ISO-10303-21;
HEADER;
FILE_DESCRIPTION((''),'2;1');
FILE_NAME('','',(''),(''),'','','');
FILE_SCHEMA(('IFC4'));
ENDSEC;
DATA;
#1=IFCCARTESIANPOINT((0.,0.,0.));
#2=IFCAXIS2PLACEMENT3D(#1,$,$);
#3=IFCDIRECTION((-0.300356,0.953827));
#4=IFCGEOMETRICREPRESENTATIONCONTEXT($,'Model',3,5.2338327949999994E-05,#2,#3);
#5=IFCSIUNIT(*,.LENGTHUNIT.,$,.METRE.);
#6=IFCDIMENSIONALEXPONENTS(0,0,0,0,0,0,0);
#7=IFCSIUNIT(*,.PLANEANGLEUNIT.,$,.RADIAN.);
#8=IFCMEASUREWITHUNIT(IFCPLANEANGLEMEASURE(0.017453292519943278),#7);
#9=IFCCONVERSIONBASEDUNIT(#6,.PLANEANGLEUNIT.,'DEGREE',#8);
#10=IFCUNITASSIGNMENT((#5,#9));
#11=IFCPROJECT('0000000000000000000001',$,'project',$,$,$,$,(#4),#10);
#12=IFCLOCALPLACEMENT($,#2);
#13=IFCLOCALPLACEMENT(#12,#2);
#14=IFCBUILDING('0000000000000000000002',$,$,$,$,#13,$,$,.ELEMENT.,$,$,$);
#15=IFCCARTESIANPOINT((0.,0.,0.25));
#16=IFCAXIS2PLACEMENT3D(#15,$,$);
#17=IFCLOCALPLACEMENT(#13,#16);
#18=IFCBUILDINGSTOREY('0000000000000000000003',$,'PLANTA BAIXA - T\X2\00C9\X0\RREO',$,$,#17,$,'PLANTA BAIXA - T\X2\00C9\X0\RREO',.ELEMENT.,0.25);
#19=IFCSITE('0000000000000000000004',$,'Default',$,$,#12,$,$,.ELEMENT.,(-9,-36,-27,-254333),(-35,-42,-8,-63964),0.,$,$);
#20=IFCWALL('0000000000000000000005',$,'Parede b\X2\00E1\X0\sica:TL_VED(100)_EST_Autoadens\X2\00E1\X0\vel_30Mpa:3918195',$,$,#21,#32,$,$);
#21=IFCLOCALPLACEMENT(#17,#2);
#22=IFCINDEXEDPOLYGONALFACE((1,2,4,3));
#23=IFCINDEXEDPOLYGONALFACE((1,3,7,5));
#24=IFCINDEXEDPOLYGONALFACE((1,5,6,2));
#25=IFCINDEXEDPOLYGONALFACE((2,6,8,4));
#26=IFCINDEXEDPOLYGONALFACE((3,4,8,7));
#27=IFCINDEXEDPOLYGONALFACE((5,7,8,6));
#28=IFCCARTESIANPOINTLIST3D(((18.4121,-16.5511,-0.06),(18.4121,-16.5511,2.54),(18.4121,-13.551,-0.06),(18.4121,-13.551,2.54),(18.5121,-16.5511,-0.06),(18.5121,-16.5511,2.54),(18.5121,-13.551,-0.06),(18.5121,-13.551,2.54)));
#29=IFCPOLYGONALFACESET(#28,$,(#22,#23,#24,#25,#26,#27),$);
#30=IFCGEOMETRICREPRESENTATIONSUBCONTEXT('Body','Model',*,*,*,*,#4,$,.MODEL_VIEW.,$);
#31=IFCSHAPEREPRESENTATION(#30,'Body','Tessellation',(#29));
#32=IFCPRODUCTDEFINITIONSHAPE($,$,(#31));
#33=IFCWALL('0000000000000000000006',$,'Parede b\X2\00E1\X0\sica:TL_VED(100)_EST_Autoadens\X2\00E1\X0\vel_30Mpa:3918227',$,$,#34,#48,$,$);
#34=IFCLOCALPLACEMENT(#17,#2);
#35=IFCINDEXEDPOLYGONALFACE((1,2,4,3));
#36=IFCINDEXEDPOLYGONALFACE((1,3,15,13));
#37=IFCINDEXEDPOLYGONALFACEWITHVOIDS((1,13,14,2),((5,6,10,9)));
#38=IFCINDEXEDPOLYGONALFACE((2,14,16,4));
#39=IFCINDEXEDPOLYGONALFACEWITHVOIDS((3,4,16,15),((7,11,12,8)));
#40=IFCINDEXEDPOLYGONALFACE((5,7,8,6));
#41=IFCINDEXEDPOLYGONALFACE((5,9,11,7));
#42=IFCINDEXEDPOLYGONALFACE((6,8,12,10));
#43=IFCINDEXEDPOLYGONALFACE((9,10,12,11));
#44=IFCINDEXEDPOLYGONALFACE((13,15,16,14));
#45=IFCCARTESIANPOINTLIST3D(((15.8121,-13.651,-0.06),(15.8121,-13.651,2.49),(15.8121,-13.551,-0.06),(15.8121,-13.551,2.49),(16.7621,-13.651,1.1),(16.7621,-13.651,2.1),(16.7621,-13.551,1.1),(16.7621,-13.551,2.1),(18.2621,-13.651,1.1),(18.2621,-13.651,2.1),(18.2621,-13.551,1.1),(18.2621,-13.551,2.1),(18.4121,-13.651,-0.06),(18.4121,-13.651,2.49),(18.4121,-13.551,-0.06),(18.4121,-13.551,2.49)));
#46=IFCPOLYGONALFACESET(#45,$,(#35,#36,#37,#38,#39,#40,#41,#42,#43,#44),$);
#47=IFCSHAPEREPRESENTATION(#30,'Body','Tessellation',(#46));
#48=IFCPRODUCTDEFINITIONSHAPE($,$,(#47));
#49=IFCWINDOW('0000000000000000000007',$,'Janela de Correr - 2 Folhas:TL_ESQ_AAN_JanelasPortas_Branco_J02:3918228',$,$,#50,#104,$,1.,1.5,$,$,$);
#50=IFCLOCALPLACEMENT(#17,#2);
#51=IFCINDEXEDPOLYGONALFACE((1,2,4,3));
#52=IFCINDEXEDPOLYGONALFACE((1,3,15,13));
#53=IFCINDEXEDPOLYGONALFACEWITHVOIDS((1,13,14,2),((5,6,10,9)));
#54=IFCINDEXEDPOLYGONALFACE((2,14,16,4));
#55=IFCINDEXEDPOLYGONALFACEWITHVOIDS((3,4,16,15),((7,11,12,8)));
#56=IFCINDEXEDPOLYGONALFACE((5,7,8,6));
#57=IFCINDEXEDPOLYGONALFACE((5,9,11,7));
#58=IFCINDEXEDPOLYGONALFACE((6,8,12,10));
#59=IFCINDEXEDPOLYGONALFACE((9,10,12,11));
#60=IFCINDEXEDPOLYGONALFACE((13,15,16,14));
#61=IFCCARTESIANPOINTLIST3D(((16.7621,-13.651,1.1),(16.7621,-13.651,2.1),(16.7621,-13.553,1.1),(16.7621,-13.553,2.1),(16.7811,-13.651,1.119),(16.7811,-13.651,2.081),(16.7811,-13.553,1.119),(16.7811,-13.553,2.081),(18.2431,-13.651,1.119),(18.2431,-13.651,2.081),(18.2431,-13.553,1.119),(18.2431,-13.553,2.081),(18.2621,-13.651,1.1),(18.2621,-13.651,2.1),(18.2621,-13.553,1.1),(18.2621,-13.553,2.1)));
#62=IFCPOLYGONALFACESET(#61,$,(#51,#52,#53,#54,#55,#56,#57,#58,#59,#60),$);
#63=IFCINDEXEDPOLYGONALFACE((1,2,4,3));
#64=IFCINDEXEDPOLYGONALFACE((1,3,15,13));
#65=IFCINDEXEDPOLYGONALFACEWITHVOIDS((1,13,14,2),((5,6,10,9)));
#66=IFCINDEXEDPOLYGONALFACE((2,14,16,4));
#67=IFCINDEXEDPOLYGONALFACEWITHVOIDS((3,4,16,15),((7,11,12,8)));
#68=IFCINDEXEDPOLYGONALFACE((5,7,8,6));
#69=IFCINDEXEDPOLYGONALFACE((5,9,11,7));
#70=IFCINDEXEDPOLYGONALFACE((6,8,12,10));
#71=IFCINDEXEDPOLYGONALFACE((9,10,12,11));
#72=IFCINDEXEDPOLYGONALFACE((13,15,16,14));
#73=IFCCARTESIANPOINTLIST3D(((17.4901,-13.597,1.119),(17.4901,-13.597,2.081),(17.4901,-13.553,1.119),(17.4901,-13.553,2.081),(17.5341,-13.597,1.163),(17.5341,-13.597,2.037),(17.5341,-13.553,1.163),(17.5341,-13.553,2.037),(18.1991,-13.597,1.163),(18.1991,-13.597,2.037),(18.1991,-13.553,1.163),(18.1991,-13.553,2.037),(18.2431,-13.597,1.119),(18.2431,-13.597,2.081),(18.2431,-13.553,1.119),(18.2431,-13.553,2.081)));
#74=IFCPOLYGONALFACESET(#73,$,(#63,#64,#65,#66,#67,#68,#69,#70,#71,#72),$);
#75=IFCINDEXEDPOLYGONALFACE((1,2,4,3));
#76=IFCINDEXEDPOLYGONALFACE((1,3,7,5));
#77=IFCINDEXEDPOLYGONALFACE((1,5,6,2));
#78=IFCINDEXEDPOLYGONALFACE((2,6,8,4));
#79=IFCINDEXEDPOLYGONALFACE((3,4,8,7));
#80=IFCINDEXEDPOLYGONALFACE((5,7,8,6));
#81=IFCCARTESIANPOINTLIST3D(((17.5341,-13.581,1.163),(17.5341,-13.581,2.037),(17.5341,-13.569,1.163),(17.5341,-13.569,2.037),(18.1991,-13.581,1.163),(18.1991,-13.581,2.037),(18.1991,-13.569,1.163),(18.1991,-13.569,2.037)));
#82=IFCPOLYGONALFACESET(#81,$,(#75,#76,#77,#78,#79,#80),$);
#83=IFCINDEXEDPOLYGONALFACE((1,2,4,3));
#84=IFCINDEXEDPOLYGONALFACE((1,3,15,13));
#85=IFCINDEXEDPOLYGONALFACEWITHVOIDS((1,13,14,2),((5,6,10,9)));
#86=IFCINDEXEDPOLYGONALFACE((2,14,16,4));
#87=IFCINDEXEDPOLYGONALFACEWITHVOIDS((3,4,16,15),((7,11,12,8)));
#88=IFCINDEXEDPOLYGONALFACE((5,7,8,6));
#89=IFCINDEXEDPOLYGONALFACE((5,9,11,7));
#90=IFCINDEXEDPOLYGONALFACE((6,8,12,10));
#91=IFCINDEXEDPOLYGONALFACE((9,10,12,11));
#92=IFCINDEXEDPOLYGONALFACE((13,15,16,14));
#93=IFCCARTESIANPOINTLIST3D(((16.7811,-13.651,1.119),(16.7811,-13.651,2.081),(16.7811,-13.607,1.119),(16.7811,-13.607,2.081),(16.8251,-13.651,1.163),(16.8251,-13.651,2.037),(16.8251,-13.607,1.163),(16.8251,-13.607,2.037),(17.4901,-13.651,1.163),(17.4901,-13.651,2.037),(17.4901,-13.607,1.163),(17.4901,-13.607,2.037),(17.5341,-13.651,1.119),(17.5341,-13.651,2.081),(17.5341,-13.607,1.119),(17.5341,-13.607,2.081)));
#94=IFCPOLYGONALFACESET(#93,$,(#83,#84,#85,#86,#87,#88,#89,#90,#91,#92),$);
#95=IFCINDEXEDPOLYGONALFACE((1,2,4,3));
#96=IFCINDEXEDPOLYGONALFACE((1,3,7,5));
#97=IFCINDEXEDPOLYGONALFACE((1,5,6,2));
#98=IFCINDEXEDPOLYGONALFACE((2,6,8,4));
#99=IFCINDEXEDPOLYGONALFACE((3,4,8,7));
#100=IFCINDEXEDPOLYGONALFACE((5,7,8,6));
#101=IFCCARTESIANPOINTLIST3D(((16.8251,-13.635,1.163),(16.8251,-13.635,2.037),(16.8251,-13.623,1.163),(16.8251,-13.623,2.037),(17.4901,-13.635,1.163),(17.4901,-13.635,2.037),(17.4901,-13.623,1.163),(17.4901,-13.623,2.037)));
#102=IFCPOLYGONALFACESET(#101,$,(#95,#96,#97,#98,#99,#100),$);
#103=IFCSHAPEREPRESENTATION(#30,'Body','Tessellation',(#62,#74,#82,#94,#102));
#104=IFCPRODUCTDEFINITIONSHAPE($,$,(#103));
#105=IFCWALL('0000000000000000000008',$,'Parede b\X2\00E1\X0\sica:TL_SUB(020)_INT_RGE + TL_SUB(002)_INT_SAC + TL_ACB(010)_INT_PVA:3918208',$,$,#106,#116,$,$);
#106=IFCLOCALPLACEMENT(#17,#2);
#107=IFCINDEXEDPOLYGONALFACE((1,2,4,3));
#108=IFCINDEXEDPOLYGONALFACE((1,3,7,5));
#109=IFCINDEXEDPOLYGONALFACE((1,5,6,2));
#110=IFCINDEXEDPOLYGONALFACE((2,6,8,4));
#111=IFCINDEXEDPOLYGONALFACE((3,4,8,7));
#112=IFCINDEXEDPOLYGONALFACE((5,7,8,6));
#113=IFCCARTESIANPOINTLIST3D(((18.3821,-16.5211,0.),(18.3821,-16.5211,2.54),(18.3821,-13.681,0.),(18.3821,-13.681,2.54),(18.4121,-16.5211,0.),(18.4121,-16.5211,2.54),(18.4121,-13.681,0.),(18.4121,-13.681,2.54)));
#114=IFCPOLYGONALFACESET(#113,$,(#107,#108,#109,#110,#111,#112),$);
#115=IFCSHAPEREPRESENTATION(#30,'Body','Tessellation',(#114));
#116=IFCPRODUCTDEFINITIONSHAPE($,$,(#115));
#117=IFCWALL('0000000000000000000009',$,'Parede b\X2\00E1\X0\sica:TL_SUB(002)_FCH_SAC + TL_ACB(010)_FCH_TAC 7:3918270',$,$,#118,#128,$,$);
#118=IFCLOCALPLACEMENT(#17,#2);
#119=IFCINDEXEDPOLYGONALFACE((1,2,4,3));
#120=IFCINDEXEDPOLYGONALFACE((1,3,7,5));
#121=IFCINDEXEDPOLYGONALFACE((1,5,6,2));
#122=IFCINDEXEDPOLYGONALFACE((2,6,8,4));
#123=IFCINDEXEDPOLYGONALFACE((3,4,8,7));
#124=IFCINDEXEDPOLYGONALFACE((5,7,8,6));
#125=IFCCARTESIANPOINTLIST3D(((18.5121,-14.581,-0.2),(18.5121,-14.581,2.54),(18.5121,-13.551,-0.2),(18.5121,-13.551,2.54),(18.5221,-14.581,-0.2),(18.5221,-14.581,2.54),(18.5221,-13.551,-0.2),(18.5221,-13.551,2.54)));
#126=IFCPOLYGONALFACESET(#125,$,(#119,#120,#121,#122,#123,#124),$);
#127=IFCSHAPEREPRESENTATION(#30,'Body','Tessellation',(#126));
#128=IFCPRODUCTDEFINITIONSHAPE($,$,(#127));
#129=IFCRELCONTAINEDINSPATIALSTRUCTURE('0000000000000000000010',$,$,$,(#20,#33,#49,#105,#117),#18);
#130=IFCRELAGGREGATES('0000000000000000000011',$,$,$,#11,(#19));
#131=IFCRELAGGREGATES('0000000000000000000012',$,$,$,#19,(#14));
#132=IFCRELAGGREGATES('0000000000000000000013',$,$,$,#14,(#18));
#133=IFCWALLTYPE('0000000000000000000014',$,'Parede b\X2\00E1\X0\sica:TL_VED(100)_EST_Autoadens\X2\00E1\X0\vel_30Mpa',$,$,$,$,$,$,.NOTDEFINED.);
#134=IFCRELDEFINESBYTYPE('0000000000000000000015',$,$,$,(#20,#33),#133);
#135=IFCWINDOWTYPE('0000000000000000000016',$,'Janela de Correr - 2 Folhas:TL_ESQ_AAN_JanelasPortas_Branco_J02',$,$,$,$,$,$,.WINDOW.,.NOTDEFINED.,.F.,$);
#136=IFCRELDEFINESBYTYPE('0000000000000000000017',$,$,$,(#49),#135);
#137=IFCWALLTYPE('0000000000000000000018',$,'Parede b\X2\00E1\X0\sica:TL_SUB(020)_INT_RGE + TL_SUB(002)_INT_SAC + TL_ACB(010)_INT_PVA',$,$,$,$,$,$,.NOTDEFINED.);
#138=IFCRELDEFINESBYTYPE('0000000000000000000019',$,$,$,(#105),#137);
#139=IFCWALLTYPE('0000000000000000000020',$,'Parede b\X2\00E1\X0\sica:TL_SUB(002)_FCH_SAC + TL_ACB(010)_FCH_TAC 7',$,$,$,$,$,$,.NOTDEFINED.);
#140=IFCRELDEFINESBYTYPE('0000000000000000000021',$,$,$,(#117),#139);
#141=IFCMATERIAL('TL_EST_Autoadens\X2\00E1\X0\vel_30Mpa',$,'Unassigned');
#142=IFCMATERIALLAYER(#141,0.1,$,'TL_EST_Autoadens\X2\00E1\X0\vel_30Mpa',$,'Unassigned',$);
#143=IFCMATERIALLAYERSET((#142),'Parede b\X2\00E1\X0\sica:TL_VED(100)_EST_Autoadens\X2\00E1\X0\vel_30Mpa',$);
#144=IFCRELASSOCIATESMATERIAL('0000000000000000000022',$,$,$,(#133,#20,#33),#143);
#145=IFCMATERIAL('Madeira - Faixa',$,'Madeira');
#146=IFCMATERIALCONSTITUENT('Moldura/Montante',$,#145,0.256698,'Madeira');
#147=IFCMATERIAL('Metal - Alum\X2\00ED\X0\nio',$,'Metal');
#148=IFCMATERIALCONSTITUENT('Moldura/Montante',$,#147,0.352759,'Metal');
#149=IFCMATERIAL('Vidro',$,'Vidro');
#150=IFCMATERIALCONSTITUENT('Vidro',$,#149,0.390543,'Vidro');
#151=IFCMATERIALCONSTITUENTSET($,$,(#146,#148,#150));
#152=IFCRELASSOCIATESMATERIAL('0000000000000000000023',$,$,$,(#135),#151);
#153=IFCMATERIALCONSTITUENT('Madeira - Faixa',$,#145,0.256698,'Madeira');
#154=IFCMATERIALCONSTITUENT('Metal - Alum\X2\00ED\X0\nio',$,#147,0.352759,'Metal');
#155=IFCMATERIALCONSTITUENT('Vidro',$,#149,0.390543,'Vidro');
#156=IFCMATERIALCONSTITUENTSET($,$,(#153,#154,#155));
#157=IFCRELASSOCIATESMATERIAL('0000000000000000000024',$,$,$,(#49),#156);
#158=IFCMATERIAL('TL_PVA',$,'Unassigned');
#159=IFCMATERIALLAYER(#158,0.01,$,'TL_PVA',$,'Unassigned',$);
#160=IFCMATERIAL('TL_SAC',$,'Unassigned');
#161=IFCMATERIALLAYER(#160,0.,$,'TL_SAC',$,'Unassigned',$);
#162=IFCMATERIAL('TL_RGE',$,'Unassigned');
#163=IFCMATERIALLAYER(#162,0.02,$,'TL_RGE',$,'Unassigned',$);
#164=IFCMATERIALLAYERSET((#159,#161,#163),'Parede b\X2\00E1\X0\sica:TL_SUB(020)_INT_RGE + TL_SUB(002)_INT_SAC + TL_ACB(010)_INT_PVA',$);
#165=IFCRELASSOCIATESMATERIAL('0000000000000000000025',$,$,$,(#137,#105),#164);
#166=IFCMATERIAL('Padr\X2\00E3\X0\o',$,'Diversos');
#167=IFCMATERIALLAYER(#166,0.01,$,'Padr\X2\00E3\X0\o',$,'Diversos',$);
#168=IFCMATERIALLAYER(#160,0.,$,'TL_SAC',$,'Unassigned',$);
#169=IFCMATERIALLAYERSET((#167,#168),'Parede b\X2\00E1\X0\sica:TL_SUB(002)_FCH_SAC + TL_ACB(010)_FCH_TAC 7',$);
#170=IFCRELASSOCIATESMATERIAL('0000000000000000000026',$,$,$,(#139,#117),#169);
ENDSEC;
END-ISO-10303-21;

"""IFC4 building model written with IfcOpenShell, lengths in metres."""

from ifc_helpers import new_model, entity, si_unit, converted_unit, direction, frame, frame_2d, origin, origin_2d_with_axis, place, context, subcontext, project, spatial, polyline, rectangle, outline, extrude, source, transform, mapped, material, layer, layer_set, layer_usage, constituent, constituent_set, type_object, type_shapes, element, fill, save


model = new_model("IFC4")

# Units and contexts
model_context = context("Model", 3, precision=5.2338327949999994e-05, world=origin(), true_north=direction((-0.300356, 0.953827)))
body_context = subcontext(model_context, "Body", "Model", "MODEL_VIEW")
ifc_project = project(units=[si_unit("LENGTHUNIT", "METRE"), converted_unit("PLANEANGLEUNIT", "DEGREE", entity("IfcPlaneAngleMeasure", 0.017453292519943278), si_unit("PLANEANGLEUNIT", "RADIAN"), dimensions=[0, 0, 0, 0, 0, 0, 0])], contexts=[model_context])

# Site, building, storey
site_placement = place(None, origin())
site = spatial("IfcSite", under=ifc_project, at=site_placement, Name="Default", CompositionType="ELEMENT", RefLatitude=(-9, -36, -27, -254333), RefLongitude=(-35, -42, -8, -63964), RefElevation=0.0)
building_placement = place(site_placement, origin())
building = spatial("IfcBuilding", under=site, at=building_placement, CompositionType="ELEMENT")
storey_placement = place(building_placement, frame((0.0, 0.0, 0.25)))
storey = spatial("IfcBuildingStorey", under=building, at=storey_placement, Name="PLANTA BAIXA - TÉRREO", LongName="PLANTA BAIXA - TÉRREO", CompositionType="ELEMENT", Elevation=0.25)

# Wall
ifc_material_1 = material(Name="TL_EST_Autoadensável_30Mpa", Category="Unassigned")
ifc_layer_1 = layer(ifc_material_1, 0.1, Name="TL_EST_Autoadensável_30Mpa", Category="Unassigned")
ifc_layer_set_1 = layer_set([ifc_layer_1], Name="Parede básica:TL_VED(100)_EST_Autoadensável_30Mpa")
ifc_layer_usage_1 = layer_usage(ifc_layer_set_1, "AXIS2", "POSITIVE", -0.05)
wall_type_1 = type_object("IfcWallType", Name="Parede básica:TL_VED(100)_EST_Autoadensável_30Mpa", PredefinedType="NOTDEFINED", material=ifc_layer_set_1)
wall_1_placement = place(storey_placement, frame((18.4621, -13.551, -0.06), z_axis=(0.0, 0.0, 1.0), x_axis=(0.0, -1.0, 0.0)))
element("IfcWall", 1, at=wall_1_placement, inside=storey, type_object=wall_type_1, material=ifc_layer_usage_1, Name="Parede básica:TL_VED(100)_EST_Autoadensável_30Mpa:3918195", context=body_context, shape_type="SweptSolid", body=[
    extrude(rectangle(XDim=3.0001, YDim=0.1, at=frame_2d((1.5001, 0.0), x_axis=(-1.0, 0.0))), origin(), (0.0, 0.0, 1.0), 2.6),
])

# Wall, opening, window
ifc_layer_usage_2 = layer_usage(ifc_layer_set_1, "AXIS2", "POSITIVE", -0.05)
wall_2_placement = place(storey_placement, frame((18.4121, -13.601, -0.06), z_axis=(0.0, 0.0, 1.0), x_axis=(-1.0, 0.0, 0.0)))
wall_2 = element("IfcWall", 2, at=wall_2_placement, inside=storey, type_object=wall_type_1, material=ifc_layer_usage_2, Name="Parede básica:TL_VED(100)_EST_Autoadensável_30Mpa:3918227", context=body_context, shape_type="SweptSolid", body=[
    extrude(rectangle(XDim=2.6, YDim=0.1, at=frame_2d((1.3, 0.0), x_axis=(-1.0, 0.0))), origin(), (0.0, 0.0, 1.0), 2.55),
])
opening_placement = place(wall_2_placement, frame((1.65, 0.05, 1.16)))
opening = element("IfcOpeningElement", 3, at=opening_placement, cuts=wall_2, PredefinedType="OPENING", context=body_context, shape_type="SweptSolid", body=[
    extrude(rectangle(XDim=1.0, YDim=1.5, at=frame_2d((0.5, 0.75), x_axis=(-1.0, 0.0))), frame((0.0, 0.0, 0.0), z_axis=(0.0, -1.0, 0.0), x_axis=(0.0, 0.0, 1.0)), (0.0, 0.0, 1.0), 0.1),
])
ifc_material_2 = material(Name="Madeira - Faixa", Category="Madeira")
ifc_constituent_1 = constituent(ifc_material_2, Name="Madeira - Faixa", Category="Madeira", fraction=0.256698)
ifc_material_3 = material(Name="Metal - Alumínio", Category="Metal")
ifc_constituent_2 = constituent(ifc_material_3, Name="Metal - Alumínio", Category="Metal", fraction=0.352759)
ifc_material_4 = material(Name="Vidro", Category="Vidro")
ifc_constituent_3 = constituent(ifc_material_4, Name="Vidro", Category="Vidro", fraction=0.390543)
ifc_constituent_set_1 = constituent_set(constituents=[ifc_constituent_1, ifc_constituent_2, ifc_constituent_3])
ifc_constituent_4 = constituent(ifc_material_2, Name="Moldura/Montante", Category="Madeira", fraction=0.256698)
ifc_constituent_5 = constituent(ifc_material_3, Name="Moldura/Montante", Category="Metal", fraction=0.352759)
ifc_constituent_6 = constituent(ifc_material_4, Name="Vidro", Category="Vidro", fraction=0.390543)
ifc_constituent_set_2 = constituent_set(constituents=[ifc_constituent_4, ifc_constituent_5, ifc_constituent_6])
window_type = type_object("IfcWindowType", Name="Janela de Correr - 2 Folhas:TL_ESQ_AAN_JanelasPortas_Branco_J02", ParameterTakesPrecedence=False, PartitioningType="NOTDEFINED", PredefinedType="WINDOW", material=ifc_constituent_set_2)
shared_shape_1 = source(origin(), body_context, "Body", "SweptSolid", [
    extrude(outline(polyline([(-0.75, -0.5), (0.75, -0.5), (0.75, 0.5), (-0.75, 0.5), (-0.75, -0.5)]), holes=[polyline([(-0.731, -0.481), (-0.731, 0.481), (0.731, 0.481), (0.731, -0.481), (-0.731, -0.481)])]), frame((0.75, 0.0, 0.5), z_axis=(0.0, 1.0, 0.0), x_axis=(1.0, 0.0, 0.0)), (0.0, 0.0, 1.0), 0.098),
    extrude(outline(polyline([(-0.3765, -0.481), (0.3765, -0.481), (0.3765, 0.481), (-0.3765, 0.481), (-0.3765, -0.481)]), holes=[polyline([(-0.3325, -0.437), (-0.3325, 0.437), (0.3325, 0.437), (0.3325, -0.437), (-0.3325, -0.437)])]), frame((1.1045, 0.054, 0.5), z_axis=(0.0, 1.0, 0.0), x_axis=(1.0, 0.0, 0.0)), (0.0, 0.0, 1.0), 0.044),
    extrude(rectangle(XDim=0.012, YDim=0.665, at=origin_2d_with_axis()), frame((1.1045, 0.076, 0.063), z_axis=(0.0, 0.0, 1.0), x_axis=(0.0, -1.0, 0.0)), (0.0, 0.0, 1.0), 0.874),
    extrude(outline(polyline([(-0.481, -0.3765), (0.481, -0.3765), (0.481, 0.3765), (-0.481, 0.3765), (-0.481, -0.3765)]), holes=[polyline([(-0.437, -0.3325), (-0.437, 0.3325), (0.437, 0.3325), (0.437, -0.3325), (-0.437, -0.3325)])]), frame((0.3955, 0.0, 0.5), z_axis=(0.0, 1.0, 0.0), x_axis=(0.0, 0.0, -1.0)), (0.0, 0.0, 1.0), 0.044),
    extrude(rectangle(XDim=0.012, YDim=0.665, at=origin_2d_with_axis()), frame((0.3955, 0.022, 0.063), z_axis=(0.0, 0.0, 1.0), x_axis=(0.0, -1.0, 0.0)), (0.0, 0.0, 1.0), 0.874),
])
type_shapes(window_type, [shared_shape_1])
window_placement = place(opening_placement, frame((0.0, 0.0, 0.0), z_axis=(0.0, 0.0, 1.0), x_axis=(-1.0, 0.0, 0.0)))
window = element("IfcWindow", 4, at=window_placement, inside=storey, type_object=window_type, material=ifc_constituent_set_1, Name="Janela de Correr - 2 Folhas:TL_ESQ_AAN_JanelasPortas_Branco_J02:3918228", OverallHeight=1.0, OverallWidth=1.5, context=body_context, shape_type="MappedRepresentation", body=[
    mapped(shared_shape_1, transform((0.0, 0.0, 0.0), scale=1.0)),
])
fill(opening, window)

# Walls
ifc_material_5 = material(Name="TL_PVA", Category="Unassigned")
ifc_layer_2 = layer(ifc_material_5, 0.01, Name="TL_PVA", Category="Unassigned")
ifc_material_6 = material(Name="TL_SAC", Category="Unassigned")
ifc_layer_3 = layer(ifc_material_6, 0.0, Name="TL_SAC", Category="Unassigned")
ifc_material_7 = material(Name="TL_RGE", Category="Unassigned")
ifc_layer_4 = layer(ifc_material_7, 0.02, Name="TL_RGE", Category="Unassigned")
ifc_layer_set_2 = layer_set([ifc_layer_2, ifc_layer_3, ifc_layer_4], Name="Parede básica:TL_SUB(020)_INT_RGE + TL_SUB(002)_INT_SAC + TL_ACB(010)_INT_PVA")
ifc_layer_usage_3 = layer_usage(ifc_layer_set_2, "AXIS2", "POSITIVE", -0.015)
wall_type_2 = type_object("IfcWallType", Name="Parede básica:TL_SUB(020)_INT_RGE + TL_SUB(002)_INT_SAC + TL_ACB(010)_INT_PVA", PredefinedType="NOTDEFINED", material=ifc_layer_set_2)
wall_3_placement = place(storey_placement, frame((18.3971, -13.681, 0.0), z_axis=(0.0, 0.0, 1.0), x_axis=(0.0, -1.0, 0.0)))
element("IfcWall", 5, at=wall_3_placement, inside=storey, type_object=wall_type_2, material=ifc_layer_usage_3, Name="Parede básica:TL_SUB(020)_INT_RGE + TL_SUB(002)_INT_SAC + TL_ACB(010)_INT_PVA:3918208", context=body_context, shape_type="SweptSolid", body=[
    extrude(rectangle(XDim=2.8401, YDim=0.03, at=frame_2d((1.4201, 0.0), x_axis=(-1.0, 0.0))), origin(), (0.0, 0.0, 1.0), 2.54),
])
ifc_material_8 = material(Name="Padrão", Category="Diversos")
ifc_layer_5 = layer(ifc_material_8, 0.01, Name="Padrão", Category="Diversos")
ifc_layer_6 = layer(ifc_material_6, 0.0, Name="TL_SAC", Category="Unassigned")
ifc_layer_set_3 = layer_set([ifc_layer_5, ifc_layer_6], Name="Parede básica:TL_SUB(002)_FCH_SAC + TL_ACB(010)_FCH_TAC 7")
ifc_layer_usage_4 = layer_usage(ifc_layer_set_3, "AXIS2", "POSITIVE", -0.005)
wall_type_3 = type_object("IfcWallType", Name="Parede básica:TL_SUB(002)_FCH_SAC + TL_ACB(010)_FCH_TAC 7", PredefinedType="NOTDEFINED", material=ifc_layer_set_3)
wall_4_placement = place(storey_placement, frame((18.5171, -13.551, -0.2), z_axis=(0.0, 0.0, 1.0), x_axis=(0.0, -1.0, 0.0)))
element("IfcWall", 6, at=wall_4_placement, inside=storey, type_object=wall_type_3, material=ifc_layer_usage_4, Name="Parede básica:TL_SUB(002)_FCH_SAC + TL_ACB(010)_FCH_TAC 7:3918270", context=body_context, shape_type="SweptSolid", body=[
    extrude(rectangle(XDim=1.03, YDim=0.01, at=frame_2d((0.515, 0.0), x_axis=(-1.0, 0.0))), origin(), (0.0, 0.0, 1.0), 2.74),
])

save(model, "model.ifc")
